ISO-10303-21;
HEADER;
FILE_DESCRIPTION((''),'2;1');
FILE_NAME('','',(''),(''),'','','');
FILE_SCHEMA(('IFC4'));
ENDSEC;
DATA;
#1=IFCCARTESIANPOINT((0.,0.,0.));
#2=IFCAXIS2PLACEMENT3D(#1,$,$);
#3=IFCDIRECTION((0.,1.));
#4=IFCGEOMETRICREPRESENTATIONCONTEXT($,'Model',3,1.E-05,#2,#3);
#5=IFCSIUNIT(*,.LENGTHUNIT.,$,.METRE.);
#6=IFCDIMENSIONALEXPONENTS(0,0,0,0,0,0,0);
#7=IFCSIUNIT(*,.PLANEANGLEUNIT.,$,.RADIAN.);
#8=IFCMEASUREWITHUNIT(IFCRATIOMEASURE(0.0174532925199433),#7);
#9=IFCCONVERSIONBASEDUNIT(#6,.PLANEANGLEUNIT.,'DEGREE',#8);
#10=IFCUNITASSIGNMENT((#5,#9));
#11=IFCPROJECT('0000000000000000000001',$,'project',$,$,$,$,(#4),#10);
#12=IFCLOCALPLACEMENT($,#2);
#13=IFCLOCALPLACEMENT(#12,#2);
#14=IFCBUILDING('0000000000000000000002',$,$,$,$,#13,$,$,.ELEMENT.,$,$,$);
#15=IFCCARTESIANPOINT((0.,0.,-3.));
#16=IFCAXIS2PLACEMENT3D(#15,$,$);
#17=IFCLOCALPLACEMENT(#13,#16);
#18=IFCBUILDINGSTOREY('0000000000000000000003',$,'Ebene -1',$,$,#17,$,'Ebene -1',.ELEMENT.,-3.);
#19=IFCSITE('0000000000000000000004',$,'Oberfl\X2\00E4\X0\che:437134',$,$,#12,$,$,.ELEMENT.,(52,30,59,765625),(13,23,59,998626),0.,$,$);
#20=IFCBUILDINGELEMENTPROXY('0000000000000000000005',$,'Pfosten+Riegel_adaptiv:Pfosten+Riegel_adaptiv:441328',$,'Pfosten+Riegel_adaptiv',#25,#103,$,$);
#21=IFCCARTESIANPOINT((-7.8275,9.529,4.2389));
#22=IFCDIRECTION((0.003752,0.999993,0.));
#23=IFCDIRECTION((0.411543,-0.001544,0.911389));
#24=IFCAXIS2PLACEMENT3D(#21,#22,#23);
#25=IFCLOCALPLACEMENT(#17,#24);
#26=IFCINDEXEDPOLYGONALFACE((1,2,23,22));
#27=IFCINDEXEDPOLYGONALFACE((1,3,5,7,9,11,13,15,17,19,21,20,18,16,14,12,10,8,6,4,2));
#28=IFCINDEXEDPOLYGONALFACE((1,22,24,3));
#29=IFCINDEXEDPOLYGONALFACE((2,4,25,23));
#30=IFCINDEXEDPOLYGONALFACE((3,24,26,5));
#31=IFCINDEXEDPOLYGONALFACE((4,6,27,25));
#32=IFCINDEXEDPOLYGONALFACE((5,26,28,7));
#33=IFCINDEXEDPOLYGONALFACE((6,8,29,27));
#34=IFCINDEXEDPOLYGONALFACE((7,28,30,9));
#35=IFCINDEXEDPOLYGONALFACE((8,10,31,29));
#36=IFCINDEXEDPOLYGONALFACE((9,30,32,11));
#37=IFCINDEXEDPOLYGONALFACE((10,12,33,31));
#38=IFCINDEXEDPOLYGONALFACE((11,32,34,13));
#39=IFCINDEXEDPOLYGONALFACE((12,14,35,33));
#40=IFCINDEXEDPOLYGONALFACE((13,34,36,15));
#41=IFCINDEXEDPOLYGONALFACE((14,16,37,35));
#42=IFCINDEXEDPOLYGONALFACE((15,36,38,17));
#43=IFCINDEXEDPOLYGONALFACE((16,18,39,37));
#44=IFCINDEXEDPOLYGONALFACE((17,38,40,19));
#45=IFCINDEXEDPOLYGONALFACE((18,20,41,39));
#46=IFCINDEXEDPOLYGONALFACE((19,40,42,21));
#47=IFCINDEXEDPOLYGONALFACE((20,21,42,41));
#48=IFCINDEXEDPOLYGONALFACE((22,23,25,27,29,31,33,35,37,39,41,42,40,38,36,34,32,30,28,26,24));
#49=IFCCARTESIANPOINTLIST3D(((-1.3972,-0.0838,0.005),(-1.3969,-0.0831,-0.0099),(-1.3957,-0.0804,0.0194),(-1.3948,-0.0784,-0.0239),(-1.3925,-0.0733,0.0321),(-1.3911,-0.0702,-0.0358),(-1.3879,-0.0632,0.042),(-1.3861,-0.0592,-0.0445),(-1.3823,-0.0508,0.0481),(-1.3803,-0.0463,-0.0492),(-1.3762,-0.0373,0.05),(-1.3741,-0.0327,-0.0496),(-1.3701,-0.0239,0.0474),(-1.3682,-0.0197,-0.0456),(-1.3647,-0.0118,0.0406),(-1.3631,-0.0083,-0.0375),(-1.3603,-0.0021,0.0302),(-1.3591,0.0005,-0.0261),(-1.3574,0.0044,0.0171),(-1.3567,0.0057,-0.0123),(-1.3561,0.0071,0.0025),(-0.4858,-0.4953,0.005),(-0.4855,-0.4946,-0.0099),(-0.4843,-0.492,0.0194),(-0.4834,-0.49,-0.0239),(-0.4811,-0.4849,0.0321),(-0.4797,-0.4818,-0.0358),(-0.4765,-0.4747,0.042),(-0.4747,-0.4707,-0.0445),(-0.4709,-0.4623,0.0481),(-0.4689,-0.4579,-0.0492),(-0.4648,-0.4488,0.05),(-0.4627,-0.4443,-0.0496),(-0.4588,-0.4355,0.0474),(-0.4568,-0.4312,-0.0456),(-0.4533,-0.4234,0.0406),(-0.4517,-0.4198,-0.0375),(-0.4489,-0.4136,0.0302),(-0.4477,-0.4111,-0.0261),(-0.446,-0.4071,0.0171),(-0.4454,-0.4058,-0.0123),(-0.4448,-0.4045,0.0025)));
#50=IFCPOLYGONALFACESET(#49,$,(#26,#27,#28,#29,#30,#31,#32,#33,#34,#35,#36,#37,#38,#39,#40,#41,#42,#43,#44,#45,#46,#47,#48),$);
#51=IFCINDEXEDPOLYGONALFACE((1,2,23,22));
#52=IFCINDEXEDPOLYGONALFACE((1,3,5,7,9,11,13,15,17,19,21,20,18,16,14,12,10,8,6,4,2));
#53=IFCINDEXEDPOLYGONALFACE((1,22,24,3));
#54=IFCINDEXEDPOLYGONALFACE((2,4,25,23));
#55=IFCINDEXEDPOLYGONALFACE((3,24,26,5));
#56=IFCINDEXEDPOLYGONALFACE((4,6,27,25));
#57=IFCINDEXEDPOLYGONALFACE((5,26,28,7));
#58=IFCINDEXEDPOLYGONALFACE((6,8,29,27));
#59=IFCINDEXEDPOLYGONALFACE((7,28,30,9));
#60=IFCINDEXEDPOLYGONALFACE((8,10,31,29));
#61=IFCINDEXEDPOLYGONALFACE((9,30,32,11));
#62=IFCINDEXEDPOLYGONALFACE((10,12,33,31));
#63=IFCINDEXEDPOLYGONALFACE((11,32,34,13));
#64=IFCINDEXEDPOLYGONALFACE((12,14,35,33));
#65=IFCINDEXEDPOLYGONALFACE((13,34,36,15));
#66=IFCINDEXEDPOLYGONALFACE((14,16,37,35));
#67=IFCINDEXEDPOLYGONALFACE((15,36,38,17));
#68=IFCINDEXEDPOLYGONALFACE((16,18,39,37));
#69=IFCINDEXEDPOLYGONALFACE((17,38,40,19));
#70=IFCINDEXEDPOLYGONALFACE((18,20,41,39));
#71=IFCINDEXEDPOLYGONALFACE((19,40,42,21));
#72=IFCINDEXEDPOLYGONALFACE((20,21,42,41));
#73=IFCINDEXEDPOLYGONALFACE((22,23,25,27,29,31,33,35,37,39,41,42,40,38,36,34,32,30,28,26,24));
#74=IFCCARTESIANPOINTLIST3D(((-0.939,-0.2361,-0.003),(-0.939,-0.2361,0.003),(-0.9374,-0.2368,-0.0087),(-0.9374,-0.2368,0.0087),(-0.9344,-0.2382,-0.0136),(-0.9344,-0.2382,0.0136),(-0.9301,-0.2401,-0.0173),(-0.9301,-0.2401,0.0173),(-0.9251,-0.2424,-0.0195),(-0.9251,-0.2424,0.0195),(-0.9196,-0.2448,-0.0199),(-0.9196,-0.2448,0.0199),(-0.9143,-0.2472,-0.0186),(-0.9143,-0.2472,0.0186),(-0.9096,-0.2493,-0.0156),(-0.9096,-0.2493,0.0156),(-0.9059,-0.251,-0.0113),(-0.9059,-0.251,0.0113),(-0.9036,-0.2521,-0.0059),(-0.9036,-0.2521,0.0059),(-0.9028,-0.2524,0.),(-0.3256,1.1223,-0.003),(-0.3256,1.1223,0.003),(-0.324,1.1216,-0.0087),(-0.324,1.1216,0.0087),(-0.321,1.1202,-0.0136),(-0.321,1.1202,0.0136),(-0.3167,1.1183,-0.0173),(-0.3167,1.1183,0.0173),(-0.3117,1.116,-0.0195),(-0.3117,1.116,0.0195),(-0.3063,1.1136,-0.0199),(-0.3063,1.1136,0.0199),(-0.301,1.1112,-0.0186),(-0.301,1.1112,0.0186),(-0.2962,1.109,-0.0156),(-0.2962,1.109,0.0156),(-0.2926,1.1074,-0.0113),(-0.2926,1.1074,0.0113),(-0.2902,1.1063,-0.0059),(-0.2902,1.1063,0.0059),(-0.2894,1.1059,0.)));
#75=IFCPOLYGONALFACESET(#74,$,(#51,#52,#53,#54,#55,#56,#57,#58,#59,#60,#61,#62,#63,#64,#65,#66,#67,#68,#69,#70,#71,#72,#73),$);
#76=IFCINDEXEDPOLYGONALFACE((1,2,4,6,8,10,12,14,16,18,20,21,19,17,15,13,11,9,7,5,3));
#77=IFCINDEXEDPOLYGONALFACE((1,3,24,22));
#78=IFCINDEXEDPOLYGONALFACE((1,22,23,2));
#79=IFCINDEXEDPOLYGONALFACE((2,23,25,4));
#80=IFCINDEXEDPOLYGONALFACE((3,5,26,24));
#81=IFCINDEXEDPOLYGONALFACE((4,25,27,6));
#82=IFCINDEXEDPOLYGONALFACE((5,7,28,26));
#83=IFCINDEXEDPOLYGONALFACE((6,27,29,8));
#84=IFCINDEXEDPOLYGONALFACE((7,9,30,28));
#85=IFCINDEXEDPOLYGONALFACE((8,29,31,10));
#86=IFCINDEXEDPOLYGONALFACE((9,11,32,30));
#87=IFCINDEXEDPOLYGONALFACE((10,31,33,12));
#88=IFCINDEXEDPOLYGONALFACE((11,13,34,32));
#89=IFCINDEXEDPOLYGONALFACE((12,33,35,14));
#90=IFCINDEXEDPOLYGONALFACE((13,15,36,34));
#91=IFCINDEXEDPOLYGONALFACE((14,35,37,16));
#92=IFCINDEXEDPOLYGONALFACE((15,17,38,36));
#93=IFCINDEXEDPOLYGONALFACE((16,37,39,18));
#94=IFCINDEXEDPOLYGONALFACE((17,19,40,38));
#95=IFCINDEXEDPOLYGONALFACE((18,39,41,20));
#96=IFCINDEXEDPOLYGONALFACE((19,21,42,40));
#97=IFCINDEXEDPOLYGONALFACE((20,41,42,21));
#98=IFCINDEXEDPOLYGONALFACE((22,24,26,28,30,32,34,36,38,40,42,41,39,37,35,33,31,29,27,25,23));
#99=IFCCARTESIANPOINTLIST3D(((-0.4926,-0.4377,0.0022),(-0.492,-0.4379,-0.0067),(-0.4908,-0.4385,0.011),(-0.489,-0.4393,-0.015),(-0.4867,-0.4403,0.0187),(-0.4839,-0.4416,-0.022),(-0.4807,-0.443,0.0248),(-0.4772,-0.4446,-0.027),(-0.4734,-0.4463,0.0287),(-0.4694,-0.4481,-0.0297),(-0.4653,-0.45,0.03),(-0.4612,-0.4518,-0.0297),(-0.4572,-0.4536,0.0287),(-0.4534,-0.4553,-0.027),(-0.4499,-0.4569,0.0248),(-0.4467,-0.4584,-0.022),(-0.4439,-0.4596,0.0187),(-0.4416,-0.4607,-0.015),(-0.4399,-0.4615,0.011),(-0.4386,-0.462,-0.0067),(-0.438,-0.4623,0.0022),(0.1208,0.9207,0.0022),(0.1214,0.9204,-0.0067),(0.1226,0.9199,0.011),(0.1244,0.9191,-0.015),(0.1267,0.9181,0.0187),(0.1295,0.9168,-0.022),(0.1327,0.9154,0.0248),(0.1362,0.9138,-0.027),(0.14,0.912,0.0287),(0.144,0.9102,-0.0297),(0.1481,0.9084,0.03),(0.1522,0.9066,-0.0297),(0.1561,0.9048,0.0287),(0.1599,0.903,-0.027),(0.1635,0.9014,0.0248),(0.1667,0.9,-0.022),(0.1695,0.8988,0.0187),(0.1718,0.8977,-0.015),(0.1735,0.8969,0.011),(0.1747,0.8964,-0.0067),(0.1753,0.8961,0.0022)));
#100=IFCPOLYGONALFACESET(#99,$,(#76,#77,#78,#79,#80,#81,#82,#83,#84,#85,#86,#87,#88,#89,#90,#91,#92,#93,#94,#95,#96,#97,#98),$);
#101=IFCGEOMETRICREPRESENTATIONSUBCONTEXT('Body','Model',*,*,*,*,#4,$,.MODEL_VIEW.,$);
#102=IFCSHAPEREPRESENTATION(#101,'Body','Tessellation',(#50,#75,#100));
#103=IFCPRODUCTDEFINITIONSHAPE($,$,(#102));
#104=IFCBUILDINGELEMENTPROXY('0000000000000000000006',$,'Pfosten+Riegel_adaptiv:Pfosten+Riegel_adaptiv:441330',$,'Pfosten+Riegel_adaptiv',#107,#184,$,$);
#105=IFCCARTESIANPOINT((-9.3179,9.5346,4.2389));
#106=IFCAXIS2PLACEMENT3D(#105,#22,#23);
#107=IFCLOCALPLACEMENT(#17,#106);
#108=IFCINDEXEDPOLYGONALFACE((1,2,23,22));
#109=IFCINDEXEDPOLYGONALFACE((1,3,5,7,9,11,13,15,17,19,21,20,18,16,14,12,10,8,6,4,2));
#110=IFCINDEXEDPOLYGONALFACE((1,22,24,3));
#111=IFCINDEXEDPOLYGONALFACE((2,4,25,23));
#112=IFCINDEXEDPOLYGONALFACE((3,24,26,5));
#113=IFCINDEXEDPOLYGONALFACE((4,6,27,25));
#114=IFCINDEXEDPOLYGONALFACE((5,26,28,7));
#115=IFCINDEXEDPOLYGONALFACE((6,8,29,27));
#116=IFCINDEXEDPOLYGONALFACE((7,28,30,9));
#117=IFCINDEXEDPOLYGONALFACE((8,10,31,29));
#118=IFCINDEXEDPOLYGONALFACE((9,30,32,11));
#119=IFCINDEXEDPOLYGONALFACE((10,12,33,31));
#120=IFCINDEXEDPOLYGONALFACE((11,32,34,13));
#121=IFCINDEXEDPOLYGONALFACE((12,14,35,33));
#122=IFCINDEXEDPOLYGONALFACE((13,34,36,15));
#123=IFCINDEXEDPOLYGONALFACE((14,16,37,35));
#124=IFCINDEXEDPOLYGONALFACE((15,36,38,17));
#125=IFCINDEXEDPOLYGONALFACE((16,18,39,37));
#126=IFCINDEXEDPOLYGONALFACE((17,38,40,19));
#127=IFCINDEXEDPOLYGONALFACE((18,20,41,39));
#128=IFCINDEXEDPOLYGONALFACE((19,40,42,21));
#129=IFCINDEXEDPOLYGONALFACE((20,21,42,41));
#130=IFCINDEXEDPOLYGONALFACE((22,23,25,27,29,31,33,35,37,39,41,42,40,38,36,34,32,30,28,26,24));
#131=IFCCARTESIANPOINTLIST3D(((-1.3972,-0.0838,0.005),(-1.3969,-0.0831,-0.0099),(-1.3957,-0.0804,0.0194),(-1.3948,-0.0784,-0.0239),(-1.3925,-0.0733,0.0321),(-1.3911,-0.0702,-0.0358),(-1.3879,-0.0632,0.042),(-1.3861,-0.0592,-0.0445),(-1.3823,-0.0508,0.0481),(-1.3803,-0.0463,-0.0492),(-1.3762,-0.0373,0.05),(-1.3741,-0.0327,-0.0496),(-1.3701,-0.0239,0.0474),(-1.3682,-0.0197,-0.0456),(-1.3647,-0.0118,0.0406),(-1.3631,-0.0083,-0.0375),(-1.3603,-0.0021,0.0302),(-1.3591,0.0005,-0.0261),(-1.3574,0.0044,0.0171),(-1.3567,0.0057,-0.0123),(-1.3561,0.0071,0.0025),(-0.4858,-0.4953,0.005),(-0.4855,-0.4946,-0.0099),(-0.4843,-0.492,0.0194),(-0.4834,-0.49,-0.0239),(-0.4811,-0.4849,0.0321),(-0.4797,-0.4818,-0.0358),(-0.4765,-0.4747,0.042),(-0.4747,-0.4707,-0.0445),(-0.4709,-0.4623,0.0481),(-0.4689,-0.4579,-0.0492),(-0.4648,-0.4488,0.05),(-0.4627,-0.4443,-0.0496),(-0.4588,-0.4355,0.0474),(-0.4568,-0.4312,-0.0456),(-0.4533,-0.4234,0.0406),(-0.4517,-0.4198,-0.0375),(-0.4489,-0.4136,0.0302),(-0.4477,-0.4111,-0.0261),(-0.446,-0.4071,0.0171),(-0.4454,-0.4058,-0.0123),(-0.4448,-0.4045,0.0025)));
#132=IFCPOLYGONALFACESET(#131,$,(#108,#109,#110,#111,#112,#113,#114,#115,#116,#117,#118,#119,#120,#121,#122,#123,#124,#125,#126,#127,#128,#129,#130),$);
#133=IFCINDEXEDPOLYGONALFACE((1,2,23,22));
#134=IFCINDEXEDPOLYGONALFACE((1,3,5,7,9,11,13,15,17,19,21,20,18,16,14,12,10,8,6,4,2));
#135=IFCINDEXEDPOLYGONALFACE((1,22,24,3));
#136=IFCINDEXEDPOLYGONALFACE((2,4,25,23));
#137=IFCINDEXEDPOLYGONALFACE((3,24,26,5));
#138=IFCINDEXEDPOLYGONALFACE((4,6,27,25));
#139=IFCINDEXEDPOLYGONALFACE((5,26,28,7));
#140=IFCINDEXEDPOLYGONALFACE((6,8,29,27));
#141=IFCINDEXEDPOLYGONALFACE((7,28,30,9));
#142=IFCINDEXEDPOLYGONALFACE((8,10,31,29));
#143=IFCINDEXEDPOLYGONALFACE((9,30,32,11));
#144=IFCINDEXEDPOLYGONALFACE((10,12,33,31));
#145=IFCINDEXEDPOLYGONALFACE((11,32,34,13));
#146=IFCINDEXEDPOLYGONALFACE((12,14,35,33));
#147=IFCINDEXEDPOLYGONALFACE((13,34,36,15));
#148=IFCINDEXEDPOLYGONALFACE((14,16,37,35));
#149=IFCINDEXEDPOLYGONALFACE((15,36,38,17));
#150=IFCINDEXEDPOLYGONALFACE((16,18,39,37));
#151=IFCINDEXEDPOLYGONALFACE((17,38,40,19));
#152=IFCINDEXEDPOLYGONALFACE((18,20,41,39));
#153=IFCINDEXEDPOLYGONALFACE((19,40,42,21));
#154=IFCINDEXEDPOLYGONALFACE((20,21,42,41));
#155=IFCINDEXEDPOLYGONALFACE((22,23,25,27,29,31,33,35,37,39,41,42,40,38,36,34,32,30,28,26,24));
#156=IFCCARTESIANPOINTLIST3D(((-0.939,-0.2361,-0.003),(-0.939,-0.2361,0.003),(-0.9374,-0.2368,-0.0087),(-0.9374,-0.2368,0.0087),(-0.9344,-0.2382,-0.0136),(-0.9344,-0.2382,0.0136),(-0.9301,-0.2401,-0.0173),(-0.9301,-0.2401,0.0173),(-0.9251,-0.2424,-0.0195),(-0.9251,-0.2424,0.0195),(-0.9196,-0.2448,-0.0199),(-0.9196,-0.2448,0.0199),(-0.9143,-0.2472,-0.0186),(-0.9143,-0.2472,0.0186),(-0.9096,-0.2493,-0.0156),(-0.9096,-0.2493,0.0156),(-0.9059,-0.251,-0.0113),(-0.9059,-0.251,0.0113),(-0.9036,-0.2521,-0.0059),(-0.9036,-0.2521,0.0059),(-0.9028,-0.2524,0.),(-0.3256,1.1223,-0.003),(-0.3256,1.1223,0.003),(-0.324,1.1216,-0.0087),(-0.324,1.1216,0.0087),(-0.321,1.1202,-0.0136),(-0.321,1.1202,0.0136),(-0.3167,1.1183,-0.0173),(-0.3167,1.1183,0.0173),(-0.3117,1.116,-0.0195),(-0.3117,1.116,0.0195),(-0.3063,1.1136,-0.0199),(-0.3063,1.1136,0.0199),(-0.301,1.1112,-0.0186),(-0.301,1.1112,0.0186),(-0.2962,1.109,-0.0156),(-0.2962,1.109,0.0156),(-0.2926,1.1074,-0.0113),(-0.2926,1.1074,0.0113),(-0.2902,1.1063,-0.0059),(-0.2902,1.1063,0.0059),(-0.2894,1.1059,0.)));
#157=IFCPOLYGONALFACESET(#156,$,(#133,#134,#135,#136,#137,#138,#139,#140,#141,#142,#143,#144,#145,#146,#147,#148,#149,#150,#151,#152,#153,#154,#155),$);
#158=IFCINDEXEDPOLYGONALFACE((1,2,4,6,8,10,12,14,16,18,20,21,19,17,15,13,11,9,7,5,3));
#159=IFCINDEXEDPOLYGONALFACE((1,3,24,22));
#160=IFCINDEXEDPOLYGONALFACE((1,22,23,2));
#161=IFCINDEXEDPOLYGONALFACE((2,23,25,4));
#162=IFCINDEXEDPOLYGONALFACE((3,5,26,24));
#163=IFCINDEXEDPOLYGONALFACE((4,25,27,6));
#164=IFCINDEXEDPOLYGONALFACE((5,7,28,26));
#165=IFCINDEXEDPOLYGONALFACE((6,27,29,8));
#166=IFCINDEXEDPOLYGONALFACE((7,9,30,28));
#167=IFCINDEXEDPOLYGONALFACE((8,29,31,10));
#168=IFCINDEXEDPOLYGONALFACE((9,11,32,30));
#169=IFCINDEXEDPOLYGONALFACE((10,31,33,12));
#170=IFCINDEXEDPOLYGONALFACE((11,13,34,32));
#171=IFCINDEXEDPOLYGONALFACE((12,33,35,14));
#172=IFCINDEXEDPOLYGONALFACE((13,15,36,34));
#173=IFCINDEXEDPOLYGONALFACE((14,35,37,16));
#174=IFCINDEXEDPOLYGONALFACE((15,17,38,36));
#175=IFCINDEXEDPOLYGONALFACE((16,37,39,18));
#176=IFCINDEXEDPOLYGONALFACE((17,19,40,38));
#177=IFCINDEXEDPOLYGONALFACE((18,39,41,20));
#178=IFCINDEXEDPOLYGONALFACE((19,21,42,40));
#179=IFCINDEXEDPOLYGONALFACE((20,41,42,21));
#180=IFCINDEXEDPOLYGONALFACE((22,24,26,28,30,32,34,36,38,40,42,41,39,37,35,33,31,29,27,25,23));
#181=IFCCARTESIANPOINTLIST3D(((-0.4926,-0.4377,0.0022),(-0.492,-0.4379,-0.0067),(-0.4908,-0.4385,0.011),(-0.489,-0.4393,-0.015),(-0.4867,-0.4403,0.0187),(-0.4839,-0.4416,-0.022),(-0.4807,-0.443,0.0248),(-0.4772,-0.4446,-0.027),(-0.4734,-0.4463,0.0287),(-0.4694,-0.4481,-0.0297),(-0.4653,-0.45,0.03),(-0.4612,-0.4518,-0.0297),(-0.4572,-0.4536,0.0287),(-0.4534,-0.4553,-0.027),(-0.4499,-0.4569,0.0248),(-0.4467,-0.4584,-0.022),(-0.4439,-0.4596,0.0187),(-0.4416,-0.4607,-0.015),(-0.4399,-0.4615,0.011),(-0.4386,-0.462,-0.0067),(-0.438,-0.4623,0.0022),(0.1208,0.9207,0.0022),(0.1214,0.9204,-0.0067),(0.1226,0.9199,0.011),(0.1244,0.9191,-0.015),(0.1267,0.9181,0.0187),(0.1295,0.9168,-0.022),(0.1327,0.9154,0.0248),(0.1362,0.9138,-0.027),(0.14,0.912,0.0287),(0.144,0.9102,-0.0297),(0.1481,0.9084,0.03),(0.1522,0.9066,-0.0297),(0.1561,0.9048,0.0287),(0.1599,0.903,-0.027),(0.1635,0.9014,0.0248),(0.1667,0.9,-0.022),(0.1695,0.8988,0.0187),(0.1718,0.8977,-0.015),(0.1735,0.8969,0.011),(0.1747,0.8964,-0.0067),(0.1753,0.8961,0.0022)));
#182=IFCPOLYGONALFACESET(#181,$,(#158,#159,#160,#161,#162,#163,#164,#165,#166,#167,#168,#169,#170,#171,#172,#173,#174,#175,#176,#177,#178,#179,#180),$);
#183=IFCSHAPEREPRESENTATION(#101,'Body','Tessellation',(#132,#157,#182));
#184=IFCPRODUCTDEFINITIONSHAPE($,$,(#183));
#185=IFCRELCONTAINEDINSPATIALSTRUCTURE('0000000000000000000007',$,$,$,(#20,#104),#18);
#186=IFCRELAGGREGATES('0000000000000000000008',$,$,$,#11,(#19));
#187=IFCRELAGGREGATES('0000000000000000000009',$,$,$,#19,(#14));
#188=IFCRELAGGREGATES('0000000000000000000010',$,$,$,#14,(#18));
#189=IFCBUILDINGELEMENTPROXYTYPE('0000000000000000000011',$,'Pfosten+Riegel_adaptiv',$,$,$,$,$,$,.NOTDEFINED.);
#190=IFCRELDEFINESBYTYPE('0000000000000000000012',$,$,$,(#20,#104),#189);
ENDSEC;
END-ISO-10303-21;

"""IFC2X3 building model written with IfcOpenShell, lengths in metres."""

from ifc_helpers import new_model, entity, si_unit, converted_unit, direction, frame, frame_2d, origin, place, context, subcontext, project, spatial, circle, extrude, source, transform, mapped, type_object, type_shapes, element, save


model = new_model("IFC2X3")

# Units and contexts
model_context = context("Model", 3, precision=1e-05, world=origin(), true_north=direction((0.0, 1.0)))
body_context = subcontext(model_context, "Body", "Model", "MODEL_VIEW")
ifc_project = project(units=[si_unit("LENGTHUNIT", "METRE"), converted_unit("PLANEANGLEUNIT", "DEGREE", entity("IfcRatioMeasure", 0.0174532925199433), si_unit("PLANEANGLEUNIT", "RADIAN"), dimensions=[0, 0, 0, 0, 0, 0, 0])], contexts=[model_context])

# Site, building, storey
site_placement = place(None, origin())
site = spatial("IfcSite", under=ifc_project, at=site_placement, Name="Oberfläche:437134", CompositionType="ELEMENT", RefLatitude=(52, 30, 59, 765625), RefLongitude=(13, 23, 59, 998626), RefElevation=0.0)
building_placement = place(site_placement, origin())
building = spatial("IfcBuilding", under=site, at=building_placement, CompositionType="ELEMENT")
storey_placement = place(building_placement, frame((0.0, 0.0, -3.0)))
storey = spatial("IfcBuildingStorey", under=building, at=storey_placement, Name="Ebene -1", LongName="Ebene -1", CompositionType="ELEMENT", Elevation=-3.0)

# Building element proxies
building_element_proxy_type_1 = type_object("IfcBuildingElementProxyType", Name="Pfosten+Riegel_adaptiv", PredefinedType="NOTDEFINED")
shared_shape_1 = source(origin(), body_context, "Body", "SweptSolid", [
    extrude(circle(Radius=0.05, at=frame_2d((0.0, 0.0), x_axis=(1.0, 0.0))), frame((-0.4653, -0.45, 0.0), z_axis=(-0.911389, 0.411546, 0.0), x_axis=(0.16937, 0.375078, -0.911389)), (0.0, 0.0, 1.0), 1.0),
    extrude(circle(Radius=0.02, at=frame_2d((0.0, 0.0), x_axis=(1.0, 0.0))), frame((-0.921, -0.2442, 0.0), z_axis=(0.411546, 0.911389, 0.0), x_axis=(0.911389, -0.411546, 0.0)), (0.0, 0.0, 1.0), 1.4904),
    extrude(circle(Radius=0.03, at=frame_2d((0.0, 0.0), x_axis=(1.0, 0.0))), frame((-0.4653, -0.45, 0.0), z_axis=(0.411546, 0.911389, 0.0), x_axis=(0.0, 0.0, 1.0)), (0.0, 0.0, 1.0), 1.4904),
])
type_shapes(building_element_proxy_type_1, [shared_shape_1])
for number, where, z_axis, x_axis, name in (
    (1, (-7.8275, 9.529, 4.2389), (0.003752, 0.999993, 0.0), (0.411543, -0.001544, 0.911389), "Pfosten+Riegel_adaptiv:Pfosten+Riegel_adaptiv:441328"),
    (2, (-9.3179, 9.5346, 4.2389), (0.003752, 0.999993, 0.0), (0.411543, -0.001544, 0.911389), "Pfosten+Riegel_adaptiv:Pfosten+Riegel_adaptiv:441330"),
):
    element("IfcBuildingElementProxy", number, at=place(storey_placement, frame(where, z_axis=z_axis, x_axis=x_axis)), inside=storey, type_object=building_element_proxy_type_1, Name=name, ObjectType="Pfosten+Riegel_adaptiv", context=body_context, shape_type="MappedRepresentation", body=[
        mapped(shared_shape_1, transform((0.0, 0.0, 0.0), scale=1.0)),
    ])

save(model, "model.ifc")
